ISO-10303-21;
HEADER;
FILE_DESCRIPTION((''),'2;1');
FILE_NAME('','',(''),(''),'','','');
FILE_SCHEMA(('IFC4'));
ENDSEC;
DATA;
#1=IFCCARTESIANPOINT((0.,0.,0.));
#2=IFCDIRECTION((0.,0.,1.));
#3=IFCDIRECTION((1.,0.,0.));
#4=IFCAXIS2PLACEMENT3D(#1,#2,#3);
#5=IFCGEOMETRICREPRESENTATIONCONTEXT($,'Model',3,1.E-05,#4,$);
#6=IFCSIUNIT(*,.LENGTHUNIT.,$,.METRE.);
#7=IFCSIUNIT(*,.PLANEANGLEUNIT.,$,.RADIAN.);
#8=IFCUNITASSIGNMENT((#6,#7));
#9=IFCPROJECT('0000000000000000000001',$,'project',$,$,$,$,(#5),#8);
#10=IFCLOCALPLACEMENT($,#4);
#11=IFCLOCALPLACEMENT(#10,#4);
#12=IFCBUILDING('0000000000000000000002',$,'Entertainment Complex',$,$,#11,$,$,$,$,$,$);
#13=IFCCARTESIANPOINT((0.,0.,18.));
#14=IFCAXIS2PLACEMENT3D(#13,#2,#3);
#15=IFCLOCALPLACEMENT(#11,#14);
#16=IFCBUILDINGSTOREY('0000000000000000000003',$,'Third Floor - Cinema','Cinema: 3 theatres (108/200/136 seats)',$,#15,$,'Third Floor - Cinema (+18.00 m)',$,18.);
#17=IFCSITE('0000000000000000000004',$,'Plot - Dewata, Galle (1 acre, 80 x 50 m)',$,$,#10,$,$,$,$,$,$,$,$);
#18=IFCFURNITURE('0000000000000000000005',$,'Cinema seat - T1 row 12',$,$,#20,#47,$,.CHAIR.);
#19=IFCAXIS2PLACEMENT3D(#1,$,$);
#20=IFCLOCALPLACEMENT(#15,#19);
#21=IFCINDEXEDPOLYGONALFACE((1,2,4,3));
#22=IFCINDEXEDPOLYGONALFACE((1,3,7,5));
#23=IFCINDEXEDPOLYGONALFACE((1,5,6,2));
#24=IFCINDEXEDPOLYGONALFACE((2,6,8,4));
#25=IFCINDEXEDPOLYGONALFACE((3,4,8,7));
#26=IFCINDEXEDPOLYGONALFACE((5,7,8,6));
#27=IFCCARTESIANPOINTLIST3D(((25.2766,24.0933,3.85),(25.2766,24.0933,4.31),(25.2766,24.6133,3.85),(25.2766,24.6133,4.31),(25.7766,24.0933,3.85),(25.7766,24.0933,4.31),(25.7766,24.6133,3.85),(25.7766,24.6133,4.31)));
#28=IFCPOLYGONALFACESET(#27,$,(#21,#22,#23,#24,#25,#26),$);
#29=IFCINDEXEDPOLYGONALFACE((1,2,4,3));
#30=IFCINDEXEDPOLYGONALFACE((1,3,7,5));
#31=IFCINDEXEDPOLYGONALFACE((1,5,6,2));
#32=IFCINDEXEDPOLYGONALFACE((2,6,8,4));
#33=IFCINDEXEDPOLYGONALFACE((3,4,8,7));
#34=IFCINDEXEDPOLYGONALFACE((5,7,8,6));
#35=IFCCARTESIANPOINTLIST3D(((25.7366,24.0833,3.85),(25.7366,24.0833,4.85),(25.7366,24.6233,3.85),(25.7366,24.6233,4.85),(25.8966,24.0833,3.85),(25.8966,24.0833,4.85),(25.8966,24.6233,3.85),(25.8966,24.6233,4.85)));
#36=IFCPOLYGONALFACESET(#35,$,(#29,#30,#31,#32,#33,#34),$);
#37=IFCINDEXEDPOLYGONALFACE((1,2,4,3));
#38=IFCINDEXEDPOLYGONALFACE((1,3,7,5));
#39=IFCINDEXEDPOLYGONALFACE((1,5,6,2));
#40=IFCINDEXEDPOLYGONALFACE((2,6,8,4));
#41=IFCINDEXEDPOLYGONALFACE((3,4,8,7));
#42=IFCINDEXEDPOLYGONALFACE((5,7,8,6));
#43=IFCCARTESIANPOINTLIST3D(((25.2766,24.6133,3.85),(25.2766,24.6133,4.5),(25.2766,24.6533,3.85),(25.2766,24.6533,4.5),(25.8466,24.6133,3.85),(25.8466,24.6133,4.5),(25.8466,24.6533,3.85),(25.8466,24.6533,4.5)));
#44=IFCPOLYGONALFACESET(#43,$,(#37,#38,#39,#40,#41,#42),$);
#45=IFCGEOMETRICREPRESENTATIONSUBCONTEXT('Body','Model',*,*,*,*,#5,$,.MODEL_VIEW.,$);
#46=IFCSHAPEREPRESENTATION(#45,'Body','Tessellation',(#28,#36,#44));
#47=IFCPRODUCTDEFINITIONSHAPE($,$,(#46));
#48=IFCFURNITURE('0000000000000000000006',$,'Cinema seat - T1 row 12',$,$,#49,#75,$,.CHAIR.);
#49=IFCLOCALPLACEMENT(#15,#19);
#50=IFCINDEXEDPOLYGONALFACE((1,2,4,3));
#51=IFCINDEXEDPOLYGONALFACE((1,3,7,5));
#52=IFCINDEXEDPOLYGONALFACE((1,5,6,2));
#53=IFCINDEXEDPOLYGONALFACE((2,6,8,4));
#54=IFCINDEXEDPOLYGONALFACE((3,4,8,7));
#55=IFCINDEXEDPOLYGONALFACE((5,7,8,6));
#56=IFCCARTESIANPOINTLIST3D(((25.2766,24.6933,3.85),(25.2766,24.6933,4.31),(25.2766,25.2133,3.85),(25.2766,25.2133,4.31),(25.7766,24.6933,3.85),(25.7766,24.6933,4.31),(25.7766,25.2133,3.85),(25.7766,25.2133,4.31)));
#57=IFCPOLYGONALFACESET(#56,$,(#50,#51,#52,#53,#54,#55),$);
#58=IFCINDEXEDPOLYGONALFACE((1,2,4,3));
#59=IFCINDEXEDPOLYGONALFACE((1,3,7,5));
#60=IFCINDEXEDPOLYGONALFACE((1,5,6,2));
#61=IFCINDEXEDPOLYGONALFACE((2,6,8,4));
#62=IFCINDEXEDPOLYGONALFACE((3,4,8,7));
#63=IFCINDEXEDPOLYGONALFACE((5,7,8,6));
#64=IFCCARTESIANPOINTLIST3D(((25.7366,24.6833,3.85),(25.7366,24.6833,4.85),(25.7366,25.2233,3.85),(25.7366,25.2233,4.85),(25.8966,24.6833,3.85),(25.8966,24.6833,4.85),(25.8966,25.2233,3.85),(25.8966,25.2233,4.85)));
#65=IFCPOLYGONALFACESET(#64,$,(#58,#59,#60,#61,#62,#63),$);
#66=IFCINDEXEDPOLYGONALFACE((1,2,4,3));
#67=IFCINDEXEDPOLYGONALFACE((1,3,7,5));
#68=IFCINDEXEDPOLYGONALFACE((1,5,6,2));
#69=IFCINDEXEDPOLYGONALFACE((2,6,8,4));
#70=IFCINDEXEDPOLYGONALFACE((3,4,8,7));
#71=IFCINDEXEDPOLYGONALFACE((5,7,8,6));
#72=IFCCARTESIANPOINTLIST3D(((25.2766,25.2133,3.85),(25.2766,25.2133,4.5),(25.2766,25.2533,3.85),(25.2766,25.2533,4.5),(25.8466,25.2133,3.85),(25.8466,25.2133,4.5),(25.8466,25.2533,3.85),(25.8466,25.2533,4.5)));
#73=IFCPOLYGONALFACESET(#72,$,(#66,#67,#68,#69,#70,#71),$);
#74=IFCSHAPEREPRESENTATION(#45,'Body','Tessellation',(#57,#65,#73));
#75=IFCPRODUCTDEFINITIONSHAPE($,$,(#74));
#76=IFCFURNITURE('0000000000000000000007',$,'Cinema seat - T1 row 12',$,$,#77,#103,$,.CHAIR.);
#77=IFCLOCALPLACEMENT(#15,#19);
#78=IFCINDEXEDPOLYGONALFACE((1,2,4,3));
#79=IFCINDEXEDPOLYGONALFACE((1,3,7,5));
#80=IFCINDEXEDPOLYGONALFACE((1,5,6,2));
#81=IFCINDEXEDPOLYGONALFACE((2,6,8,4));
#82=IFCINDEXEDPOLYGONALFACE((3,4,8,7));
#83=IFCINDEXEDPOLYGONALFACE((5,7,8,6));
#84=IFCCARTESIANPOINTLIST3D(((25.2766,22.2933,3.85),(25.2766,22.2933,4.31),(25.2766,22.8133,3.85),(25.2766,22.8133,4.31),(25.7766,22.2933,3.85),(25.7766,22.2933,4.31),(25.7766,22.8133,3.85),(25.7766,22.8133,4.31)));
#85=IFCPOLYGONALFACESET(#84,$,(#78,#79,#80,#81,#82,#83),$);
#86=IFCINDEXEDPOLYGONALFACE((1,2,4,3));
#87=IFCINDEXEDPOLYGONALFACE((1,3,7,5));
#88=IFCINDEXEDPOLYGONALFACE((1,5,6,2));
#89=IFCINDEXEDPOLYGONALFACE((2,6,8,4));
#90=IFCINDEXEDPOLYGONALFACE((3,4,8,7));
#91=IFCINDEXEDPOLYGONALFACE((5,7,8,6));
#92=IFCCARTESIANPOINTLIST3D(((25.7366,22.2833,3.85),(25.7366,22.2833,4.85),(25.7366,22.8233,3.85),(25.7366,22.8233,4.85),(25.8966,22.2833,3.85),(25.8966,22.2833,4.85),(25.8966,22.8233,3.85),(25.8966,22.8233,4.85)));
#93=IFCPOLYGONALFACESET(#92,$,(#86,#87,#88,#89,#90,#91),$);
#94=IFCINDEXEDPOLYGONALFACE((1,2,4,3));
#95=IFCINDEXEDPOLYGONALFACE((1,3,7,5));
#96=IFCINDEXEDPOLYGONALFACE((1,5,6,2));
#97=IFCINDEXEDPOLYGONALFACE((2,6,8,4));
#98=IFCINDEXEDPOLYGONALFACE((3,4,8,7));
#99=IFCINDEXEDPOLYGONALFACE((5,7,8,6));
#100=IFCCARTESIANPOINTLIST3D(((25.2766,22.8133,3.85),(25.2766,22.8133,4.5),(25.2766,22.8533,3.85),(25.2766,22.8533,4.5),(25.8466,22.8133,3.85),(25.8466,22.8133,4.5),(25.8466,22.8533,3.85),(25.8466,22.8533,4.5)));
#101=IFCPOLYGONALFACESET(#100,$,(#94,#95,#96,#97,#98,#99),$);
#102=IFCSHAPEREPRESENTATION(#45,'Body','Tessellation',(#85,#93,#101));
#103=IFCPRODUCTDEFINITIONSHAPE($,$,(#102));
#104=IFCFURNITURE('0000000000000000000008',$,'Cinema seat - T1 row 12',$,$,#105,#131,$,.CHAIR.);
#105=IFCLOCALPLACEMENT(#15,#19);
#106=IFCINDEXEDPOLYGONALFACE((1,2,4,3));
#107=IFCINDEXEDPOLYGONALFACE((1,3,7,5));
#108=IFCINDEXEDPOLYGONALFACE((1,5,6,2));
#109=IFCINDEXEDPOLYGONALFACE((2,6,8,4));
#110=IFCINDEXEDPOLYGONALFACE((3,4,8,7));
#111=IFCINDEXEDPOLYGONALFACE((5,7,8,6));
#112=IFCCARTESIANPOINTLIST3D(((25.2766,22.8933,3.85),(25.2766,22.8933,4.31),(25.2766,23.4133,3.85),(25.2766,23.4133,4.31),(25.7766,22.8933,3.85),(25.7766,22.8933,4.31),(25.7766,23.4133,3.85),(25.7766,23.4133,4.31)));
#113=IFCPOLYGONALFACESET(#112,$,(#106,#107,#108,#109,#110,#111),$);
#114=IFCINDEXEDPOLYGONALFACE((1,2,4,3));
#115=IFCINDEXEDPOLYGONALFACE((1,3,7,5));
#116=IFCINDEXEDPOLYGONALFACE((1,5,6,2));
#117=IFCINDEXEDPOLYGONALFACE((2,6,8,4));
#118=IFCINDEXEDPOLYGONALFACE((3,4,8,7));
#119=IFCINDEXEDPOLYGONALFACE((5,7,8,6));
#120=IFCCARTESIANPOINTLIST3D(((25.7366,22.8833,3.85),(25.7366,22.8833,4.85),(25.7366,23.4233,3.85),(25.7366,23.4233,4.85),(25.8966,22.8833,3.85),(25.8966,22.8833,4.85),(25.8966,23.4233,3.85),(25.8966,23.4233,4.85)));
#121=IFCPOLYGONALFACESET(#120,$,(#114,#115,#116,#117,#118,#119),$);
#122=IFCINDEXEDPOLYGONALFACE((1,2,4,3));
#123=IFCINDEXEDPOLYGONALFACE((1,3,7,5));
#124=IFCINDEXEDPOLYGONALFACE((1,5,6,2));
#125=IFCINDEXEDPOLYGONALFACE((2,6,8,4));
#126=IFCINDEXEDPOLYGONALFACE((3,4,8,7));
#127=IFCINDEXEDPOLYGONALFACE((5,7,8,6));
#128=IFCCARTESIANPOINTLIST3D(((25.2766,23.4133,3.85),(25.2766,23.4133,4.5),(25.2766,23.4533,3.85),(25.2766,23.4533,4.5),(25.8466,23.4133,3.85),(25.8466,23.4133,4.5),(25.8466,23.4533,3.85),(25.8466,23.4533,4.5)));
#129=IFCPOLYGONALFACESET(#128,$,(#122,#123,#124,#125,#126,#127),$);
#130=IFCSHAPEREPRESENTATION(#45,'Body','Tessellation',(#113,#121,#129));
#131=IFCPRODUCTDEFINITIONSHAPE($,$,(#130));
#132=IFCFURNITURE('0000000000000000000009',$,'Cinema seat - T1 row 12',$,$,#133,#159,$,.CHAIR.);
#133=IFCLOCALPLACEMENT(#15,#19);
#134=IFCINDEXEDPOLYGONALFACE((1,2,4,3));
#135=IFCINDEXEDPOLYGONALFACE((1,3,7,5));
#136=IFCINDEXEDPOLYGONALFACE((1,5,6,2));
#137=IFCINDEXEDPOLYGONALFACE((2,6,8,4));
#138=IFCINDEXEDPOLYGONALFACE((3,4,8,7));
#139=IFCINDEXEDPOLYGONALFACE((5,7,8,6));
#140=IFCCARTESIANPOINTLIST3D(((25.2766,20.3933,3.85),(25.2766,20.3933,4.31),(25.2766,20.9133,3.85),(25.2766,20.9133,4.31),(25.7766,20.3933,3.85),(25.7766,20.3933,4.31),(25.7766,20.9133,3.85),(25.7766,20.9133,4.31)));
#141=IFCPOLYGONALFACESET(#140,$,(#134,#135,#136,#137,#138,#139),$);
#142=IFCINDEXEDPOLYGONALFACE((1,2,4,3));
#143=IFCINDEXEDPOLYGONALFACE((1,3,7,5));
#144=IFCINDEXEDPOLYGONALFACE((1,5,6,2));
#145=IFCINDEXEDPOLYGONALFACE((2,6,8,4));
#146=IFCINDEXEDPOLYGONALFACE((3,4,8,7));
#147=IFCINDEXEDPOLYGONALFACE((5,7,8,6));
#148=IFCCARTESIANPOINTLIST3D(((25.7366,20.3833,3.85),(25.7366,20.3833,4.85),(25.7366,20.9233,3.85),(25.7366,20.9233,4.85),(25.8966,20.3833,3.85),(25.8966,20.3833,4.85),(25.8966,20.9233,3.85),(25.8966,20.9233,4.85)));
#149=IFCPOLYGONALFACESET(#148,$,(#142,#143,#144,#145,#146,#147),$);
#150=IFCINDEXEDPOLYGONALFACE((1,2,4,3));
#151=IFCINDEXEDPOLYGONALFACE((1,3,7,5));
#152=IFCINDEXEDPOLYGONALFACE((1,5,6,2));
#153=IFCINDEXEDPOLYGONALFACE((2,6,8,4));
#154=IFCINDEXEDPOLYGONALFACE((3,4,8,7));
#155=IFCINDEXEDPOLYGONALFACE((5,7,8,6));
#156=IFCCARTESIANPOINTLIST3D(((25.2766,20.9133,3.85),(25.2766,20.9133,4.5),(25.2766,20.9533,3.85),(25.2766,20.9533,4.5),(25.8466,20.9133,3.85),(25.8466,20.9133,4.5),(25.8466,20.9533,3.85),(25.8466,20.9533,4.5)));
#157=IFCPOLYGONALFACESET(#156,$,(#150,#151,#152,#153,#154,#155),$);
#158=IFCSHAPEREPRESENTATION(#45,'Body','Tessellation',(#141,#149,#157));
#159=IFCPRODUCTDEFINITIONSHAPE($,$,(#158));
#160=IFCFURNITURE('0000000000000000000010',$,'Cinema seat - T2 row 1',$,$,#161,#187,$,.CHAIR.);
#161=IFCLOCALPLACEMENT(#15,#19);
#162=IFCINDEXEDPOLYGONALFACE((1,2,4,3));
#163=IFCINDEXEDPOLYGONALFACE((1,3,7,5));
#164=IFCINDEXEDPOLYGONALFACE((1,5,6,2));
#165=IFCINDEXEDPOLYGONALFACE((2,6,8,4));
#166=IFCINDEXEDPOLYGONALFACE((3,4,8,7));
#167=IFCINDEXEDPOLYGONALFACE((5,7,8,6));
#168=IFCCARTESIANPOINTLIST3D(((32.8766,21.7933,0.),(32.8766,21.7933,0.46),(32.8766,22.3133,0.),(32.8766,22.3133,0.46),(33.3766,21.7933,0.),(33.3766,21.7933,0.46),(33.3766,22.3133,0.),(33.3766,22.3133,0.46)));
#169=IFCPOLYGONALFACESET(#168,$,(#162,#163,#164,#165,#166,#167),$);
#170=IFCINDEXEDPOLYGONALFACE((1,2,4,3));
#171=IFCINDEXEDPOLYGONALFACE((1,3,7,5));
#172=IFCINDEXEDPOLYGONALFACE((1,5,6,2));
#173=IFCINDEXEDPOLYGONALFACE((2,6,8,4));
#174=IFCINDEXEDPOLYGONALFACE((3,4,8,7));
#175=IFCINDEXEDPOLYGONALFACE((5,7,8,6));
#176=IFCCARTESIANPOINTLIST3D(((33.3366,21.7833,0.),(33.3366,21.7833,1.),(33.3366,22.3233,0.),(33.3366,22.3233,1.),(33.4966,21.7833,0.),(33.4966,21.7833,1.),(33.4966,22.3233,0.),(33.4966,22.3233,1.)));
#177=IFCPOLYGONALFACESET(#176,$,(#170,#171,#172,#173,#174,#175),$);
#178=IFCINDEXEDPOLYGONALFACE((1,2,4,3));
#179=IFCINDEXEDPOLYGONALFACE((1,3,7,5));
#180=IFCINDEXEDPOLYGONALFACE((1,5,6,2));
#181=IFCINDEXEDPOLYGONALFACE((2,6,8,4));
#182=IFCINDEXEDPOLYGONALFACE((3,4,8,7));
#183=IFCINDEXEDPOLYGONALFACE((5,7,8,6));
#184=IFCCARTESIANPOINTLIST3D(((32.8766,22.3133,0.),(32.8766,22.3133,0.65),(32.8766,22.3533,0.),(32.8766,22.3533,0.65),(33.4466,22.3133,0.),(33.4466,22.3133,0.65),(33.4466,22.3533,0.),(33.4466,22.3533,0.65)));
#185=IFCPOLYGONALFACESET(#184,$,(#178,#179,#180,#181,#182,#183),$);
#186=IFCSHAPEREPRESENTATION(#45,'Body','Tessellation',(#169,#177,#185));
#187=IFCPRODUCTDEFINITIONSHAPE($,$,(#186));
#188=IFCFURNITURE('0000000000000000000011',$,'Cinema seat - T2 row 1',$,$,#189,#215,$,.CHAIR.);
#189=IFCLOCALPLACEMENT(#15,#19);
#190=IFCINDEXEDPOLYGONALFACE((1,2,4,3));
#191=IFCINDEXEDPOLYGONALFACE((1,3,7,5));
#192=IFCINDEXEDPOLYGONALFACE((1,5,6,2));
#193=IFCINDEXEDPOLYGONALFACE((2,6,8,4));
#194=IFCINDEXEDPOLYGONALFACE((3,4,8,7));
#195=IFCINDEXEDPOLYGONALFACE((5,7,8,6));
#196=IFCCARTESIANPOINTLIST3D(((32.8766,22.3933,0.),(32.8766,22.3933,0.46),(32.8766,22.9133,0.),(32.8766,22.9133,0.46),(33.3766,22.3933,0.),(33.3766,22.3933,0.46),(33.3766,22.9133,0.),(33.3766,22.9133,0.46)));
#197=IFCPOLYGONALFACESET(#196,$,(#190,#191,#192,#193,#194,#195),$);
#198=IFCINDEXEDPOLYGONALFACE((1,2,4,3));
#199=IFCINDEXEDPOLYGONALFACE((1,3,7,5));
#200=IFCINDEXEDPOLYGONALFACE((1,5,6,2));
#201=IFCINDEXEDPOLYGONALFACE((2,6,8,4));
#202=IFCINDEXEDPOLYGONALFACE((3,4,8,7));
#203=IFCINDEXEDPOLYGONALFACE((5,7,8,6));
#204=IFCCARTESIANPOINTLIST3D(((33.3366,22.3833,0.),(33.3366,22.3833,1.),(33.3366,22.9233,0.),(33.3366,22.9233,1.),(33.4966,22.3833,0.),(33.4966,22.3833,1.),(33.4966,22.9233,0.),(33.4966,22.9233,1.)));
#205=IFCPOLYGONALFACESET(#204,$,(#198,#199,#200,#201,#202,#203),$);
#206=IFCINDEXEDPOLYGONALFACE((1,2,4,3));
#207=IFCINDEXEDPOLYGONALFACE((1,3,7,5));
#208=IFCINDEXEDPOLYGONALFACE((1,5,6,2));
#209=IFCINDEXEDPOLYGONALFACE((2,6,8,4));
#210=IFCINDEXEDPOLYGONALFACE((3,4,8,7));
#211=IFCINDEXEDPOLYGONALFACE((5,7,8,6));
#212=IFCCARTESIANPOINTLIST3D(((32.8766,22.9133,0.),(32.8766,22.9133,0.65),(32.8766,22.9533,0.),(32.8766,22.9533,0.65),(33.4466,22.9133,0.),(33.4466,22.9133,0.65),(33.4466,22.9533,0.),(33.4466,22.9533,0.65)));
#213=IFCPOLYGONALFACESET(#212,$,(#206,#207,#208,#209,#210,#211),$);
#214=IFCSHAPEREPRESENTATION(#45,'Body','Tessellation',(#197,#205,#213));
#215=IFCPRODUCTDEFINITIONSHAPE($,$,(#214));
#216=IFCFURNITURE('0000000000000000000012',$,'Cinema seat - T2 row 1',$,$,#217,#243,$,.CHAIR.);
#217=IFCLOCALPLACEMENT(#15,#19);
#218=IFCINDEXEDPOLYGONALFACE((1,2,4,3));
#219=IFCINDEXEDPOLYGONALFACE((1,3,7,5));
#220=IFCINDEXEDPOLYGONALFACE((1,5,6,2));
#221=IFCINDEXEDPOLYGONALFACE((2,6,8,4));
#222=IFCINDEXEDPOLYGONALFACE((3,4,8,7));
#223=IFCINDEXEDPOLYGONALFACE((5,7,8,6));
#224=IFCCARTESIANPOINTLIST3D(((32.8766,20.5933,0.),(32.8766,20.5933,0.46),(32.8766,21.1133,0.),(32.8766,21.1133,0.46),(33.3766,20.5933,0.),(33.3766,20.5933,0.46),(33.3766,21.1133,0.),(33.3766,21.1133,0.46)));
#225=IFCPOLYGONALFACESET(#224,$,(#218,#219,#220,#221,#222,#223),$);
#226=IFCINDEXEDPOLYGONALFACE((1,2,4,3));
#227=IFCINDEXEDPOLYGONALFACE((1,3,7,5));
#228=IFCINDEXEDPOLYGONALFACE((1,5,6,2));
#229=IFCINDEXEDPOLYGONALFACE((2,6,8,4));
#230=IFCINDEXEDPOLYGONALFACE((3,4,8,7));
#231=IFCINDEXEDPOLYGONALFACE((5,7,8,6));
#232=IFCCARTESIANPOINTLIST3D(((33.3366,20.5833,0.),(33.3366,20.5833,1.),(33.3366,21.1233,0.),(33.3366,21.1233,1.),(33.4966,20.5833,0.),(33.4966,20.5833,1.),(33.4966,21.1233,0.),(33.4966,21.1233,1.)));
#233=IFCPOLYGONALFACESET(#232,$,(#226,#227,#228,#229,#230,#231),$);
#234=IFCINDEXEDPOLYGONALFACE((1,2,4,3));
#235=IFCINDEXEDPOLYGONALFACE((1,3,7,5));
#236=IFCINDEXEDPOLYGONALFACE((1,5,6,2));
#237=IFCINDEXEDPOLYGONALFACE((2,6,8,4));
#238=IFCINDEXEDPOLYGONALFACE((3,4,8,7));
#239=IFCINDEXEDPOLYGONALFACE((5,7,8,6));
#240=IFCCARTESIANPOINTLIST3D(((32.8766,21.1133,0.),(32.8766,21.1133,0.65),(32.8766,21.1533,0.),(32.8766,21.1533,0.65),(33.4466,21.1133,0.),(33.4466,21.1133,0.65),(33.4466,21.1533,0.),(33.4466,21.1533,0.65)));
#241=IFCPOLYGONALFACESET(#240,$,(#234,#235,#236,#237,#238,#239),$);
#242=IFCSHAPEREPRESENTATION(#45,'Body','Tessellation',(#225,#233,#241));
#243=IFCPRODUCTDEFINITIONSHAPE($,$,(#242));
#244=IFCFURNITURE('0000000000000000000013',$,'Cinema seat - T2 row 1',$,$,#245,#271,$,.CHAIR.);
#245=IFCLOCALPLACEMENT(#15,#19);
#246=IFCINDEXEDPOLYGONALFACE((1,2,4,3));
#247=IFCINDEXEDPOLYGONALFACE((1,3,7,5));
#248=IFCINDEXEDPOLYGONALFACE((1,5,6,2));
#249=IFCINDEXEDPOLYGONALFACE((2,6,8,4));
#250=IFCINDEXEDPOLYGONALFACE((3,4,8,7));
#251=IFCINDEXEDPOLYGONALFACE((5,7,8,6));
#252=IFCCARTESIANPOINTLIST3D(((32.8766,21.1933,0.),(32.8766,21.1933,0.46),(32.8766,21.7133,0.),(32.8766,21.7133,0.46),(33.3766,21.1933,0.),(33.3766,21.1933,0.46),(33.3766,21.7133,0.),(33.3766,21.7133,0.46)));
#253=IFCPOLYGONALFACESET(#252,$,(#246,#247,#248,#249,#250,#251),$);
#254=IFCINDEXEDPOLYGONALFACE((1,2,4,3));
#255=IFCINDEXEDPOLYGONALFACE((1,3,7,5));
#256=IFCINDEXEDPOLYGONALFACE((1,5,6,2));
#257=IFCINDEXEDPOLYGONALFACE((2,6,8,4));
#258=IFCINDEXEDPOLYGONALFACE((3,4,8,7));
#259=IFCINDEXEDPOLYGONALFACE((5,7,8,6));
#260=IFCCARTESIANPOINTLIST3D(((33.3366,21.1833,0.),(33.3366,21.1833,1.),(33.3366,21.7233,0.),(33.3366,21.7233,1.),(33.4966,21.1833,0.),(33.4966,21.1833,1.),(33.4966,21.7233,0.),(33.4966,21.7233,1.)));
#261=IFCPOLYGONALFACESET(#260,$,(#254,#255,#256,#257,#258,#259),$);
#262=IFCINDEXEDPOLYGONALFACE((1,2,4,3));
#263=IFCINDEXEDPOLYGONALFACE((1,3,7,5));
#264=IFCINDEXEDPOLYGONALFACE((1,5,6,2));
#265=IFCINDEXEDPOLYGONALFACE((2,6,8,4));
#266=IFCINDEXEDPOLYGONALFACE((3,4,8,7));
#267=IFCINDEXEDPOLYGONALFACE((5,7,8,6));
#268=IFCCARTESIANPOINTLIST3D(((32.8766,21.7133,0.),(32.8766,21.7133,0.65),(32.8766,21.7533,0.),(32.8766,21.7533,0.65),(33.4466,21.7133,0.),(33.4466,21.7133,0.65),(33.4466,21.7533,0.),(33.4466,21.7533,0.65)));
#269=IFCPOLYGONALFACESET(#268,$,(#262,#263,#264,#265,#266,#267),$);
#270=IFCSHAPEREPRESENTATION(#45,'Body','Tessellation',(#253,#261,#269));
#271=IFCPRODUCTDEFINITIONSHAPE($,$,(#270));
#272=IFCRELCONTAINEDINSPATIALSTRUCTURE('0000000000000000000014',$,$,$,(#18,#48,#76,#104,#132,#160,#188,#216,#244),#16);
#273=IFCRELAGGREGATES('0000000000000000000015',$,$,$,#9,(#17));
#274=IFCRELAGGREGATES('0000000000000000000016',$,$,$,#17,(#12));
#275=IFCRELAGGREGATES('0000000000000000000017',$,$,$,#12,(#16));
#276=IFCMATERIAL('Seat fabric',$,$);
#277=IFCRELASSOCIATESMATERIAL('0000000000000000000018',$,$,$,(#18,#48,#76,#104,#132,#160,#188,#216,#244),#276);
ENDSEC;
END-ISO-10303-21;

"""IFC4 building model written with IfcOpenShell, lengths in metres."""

from ifc_helpers import new_model, si_unit, frame, origin_with_axes, place, context, subcontext, project, spatial, polyline, outline, extrude, material, element, save


model = new_model("IFC4")

# Units and contexts
model_context = context("Model", 3, precision=1e-05, world=origin_with_axes())
body_context = subcontext(model_context, "Body", "Model", "MODEL_VIEW")
ifc_project = project(units=[si_unit("LENGTHUNIT", "METRE"), si_unit("PLANEANGLEUNIT", "RADIAN")], contexts=[model_context])

# Site, building, storey
site_placement = place(None, origin_with_axes())
site = spatial("IfcSite", under=ifc_project, at=site_placement, Name="Plot - Dewata, Galle (1 acre, 80 x 50 m)")
building_placement = place(site_placement, origin_with_axes())
building = spatial("IfcBuilding", under=site, at=building_placement, Name="Entertainment Complex")
storey_placement = place(building_placement, frame((0.0, 0.0, 18.0), z_axis=(0.0, 0.0, 1.0), x_axis=(1.0, 0.0, 0.0)))
storey = spatial("IfcBuildingStorey", under=building, at=storey_placement, Name="Third Floor - Cinema", Description="Cinema: 3 theatres (108/200/136 seats)", LongName="Third Floor - Cinema (+18.00 m)", Elevation=18.0)

# Furniture
ifc_material_1 = material(Name="Seat fabric")
for number, where, z_axis, x_axis, name in (
    (1, (25.8966, 24.3533, 3.85), (0.0, 0.0, 1.0), (1.0, 0.0, 0.0), "Cinema seat - T1 row 12"),
    (2, (25.8966, 24.9533, 3.85), (0.0, 0.0, 1.0), (1.0, 0.0, 0.0), "Cinema seat - T1 row 12"),
    (3, (25.8966, 22.5533, 3.85), (0.0, 0.0, 1.0), (1.0, 0.0, 0.0), "Cinema seat - T1 row 12"),
    (4, (25.8966, 23.1533, 3.85), (0.0, 0.0, 1.0), (1.0, 0.0, 0.0), "Cinema seat - T1 row 12"),
    (5, (25.8966, 20.6533, 3.85), (0.0, 0.0, 1.0), (1.0, 0.0, 0.0), "Cinema seat - T1 row 12"),
    (6, (33.4966, 22.0533, 0.0), (0.0, 0.0, 1.0), (1.0, 0.0, 0.0), "Cinema seat - T2 row 1"),
    (7, (33.4966, 22.6533, 0.0), (0.0, 0.0, 1.0), (1.0, 0.0, 0.0), "Cinema seat - T2 row 1"),
    (8, (33.4966, 20.8533, 0.0), (0.0, 0.0, 1.0), (1.0, 0.0, 0.0), "Cinema seat - T2 row 1"),
    (9, (33.4966, 21.4533, 0.0), (0.0, 0.0, 1.0), (1.0, 0.0, 0.0), "Cinema seat - T2 row 1"),
):
    element("IfcFurniture", number, at=place(storey_placement, frame(where, z_axis=z_axis, x_axis=x_axis)), inside=storey, material=ifc_material_1, Name=name, PredefinedType="CHAIR", context=body_context, shape_type="SweptSolid", body=[
        extrude(outline(polyline([(-0.62, -0.26), (-0.12, -0.26), (-0.12, 0.26), (-0.62, 0.26), (-0.62, -0.26)])), origin_with_axes(), (0.0, 0.0, 1.0), 0.46),
        extrude(outline(polyline([(-0.16, -0.27), (0.0, -0.27), (0.0, 0.27), (-0.16, 0.27), (-0.16, -0.27)])), origin_with_axes(), (0.0, 0.0, 1.0), 1.0),
        extrude(outline(polyline([(-0.62, 0.26), (-0.05, 0.26), (-0.05, 0.3), (-0.62, 0.3), (-0.62, 0.26)])), origin_with_axes(), (0.0, 0.0, 1.0), 0.65),
    ])

save(model, "model.ifc")
